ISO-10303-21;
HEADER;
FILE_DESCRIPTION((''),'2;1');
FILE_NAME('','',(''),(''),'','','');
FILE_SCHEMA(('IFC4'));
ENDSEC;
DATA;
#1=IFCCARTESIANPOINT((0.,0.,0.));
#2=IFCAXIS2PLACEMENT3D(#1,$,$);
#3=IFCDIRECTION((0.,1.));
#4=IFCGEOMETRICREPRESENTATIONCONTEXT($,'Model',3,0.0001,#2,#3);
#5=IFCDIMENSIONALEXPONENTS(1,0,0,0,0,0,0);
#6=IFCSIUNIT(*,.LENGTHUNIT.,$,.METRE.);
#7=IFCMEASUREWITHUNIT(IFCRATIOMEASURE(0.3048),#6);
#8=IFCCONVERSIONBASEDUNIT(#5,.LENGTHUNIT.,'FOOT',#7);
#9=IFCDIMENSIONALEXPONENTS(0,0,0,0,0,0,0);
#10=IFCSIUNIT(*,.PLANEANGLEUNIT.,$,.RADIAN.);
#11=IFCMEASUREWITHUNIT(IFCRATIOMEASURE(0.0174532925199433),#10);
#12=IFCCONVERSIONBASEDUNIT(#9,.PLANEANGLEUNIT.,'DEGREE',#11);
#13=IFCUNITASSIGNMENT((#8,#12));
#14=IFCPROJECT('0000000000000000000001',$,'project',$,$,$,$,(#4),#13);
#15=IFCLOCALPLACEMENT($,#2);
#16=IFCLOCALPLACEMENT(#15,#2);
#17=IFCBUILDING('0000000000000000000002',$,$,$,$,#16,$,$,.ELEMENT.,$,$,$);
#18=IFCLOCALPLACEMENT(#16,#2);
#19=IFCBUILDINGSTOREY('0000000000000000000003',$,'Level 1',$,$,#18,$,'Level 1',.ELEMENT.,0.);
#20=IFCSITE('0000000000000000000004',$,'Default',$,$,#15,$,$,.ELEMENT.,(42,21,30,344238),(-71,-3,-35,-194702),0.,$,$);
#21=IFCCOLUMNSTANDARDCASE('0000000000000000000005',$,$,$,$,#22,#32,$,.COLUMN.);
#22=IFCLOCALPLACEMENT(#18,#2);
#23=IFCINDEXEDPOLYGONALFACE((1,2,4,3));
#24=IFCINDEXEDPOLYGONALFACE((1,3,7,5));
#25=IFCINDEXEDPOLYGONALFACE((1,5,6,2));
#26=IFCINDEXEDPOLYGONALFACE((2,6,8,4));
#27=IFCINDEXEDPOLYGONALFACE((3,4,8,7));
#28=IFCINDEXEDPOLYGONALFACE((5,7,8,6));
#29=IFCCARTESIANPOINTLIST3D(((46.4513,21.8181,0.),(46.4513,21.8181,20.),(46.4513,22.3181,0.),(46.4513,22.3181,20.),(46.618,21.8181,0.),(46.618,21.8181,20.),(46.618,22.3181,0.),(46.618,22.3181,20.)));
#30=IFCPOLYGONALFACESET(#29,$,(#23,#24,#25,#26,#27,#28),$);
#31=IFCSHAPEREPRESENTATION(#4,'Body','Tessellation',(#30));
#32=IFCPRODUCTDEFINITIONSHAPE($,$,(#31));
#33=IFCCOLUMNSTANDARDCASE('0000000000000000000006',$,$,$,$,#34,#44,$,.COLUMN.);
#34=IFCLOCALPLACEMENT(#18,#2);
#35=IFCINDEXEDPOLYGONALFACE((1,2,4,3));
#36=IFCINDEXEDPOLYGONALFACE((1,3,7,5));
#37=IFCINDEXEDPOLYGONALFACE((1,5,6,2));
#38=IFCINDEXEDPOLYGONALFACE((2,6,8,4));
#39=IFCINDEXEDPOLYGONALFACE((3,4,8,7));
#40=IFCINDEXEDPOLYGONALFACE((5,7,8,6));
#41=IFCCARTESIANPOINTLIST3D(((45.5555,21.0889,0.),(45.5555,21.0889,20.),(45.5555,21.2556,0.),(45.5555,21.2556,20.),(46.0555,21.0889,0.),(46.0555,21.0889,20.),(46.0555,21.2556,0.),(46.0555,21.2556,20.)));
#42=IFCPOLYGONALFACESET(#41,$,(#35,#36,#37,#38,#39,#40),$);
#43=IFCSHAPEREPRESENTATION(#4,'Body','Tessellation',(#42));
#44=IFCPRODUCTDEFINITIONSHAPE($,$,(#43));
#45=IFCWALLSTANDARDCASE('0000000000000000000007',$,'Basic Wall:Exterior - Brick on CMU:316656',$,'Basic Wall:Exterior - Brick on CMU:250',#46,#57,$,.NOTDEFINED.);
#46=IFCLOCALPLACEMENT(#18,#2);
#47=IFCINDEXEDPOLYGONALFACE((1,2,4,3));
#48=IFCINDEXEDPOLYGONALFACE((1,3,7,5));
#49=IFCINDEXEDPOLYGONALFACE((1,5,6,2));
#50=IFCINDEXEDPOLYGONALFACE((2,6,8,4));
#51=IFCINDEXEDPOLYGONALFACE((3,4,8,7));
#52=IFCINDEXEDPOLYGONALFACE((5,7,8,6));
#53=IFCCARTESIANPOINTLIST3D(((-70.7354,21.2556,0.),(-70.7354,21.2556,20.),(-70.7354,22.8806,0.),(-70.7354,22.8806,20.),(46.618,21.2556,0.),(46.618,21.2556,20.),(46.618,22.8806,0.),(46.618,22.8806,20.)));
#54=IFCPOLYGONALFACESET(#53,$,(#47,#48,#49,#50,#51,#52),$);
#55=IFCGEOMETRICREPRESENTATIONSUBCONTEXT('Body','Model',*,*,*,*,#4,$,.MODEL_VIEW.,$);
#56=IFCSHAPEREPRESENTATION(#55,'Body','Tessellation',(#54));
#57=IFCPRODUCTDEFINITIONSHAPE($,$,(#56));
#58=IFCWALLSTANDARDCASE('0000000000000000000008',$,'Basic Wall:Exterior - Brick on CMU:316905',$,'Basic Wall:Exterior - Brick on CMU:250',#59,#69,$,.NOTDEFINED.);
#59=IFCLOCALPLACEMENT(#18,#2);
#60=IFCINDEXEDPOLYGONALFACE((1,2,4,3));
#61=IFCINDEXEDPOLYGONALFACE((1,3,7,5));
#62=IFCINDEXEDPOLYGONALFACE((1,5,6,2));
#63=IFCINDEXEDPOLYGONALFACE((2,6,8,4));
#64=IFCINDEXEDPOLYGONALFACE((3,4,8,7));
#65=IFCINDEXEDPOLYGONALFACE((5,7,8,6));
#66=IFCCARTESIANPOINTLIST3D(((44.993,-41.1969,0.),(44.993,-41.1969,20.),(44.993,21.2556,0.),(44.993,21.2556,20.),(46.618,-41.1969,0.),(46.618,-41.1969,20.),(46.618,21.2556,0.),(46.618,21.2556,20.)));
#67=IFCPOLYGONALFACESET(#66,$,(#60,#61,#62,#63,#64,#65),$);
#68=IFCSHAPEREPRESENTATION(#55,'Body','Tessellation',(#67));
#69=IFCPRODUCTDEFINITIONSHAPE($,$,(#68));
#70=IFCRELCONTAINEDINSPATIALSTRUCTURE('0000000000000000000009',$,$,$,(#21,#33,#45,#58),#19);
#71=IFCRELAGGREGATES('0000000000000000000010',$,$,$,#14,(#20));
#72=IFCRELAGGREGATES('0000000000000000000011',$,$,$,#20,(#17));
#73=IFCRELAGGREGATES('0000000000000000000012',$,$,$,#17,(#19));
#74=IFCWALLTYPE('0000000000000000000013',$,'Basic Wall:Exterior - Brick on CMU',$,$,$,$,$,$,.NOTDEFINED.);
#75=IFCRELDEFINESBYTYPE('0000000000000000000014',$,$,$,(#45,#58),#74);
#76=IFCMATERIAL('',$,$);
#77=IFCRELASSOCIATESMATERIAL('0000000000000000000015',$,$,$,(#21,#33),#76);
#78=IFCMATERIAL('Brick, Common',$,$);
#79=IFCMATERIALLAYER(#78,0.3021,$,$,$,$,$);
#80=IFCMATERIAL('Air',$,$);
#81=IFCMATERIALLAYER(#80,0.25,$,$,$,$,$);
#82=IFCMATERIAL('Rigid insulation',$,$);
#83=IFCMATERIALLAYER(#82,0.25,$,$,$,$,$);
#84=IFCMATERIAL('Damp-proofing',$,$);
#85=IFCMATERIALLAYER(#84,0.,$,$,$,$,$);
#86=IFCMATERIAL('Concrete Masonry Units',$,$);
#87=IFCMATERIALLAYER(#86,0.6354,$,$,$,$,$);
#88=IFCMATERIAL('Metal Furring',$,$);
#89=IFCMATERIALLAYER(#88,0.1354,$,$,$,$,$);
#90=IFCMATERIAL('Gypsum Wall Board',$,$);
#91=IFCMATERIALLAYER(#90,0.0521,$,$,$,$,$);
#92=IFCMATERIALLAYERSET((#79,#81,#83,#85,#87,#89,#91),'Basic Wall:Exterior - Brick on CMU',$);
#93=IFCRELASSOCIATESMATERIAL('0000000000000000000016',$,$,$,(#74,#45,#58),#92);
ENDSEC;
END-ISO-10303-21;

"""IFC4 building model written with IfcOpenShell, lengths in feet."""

from ifc_helpers import new_model, entity, si_unit, converted_unit, direction, frame, frame_2d, origin, place, context, subcontext, project, spatial, rectangle, extrude, material, layer, layer_set, layer_usage, type_object, element, save


model = new_model("IFC4")

# Units and contexts
model_context = context("Model", 3, precision=0.0001, world=origin(), true_north=direction((0.0, 1.0)))
body_context = subcontext(model_context, "Body", "Model", "MODEL_VIEW")
ifc_project = project(units=[converted_unit("LENGTHUNIT", "FOOT", entity("IfcRatioMeasure", 0.3048), si_unit("LENGTHUNIT", "METRE"), dimensions=[1, 0, 0, 0, 0, 0, 0]), converted_unit("PLANEANGLEUNIT", "DEGREE", entity("IfcRatioMeasure", 0.0174532925199433), si_unit("PLANEANGLEUNIT", "RADIAN"), dimensions=[0, 0, 0, 0, 0, 0, 0])], contexts=[model_context])

# Site, building, storey
site_placement = place(None, origin())
site = spatial("IfcSite", under=ifc_project, at=site_placement, Name="Default", CompositionType="ELEMENT", RefLatitude=(42, 21, 30, 344238), RefLongitude=(-71, -3, -35, -194702), RefElevation=0.0)
building_placement = place(site_placement, origin())
building = spatial("IfcBuilding", under=site, at=building_placement, CompositionType="ELEMENT")
storey_placement = place(building_placement, origin())
storey = spatial("IfcBuildingStorey", under=building, at=storey_placement, Name="Level 1", LongName="Level 1", CompositionType="ELEMENT", Elevation=0.0)

# Columns
ifc_material_1 = material(Name="")
wall_1_placement = place(storey_placement, frame((46.618, 22.0681, 0.0), z_axis=(0.0, 0.0, 1.0), x_axis=(-1.0, 0.0, 0.0)))
for number, where, z_axis, x_axis in (
    (1, (0.0833, 0.0, 0.0), (0.0, 0.0, 1.0), (1.0, 0.0, 0.0)),
):
    element("IfcColumnStandardCase", number, at=place(wall_1_placement, frame(where, z_axis=z_axis, x_axis=x_axis)), inside=storey, material=ifc_material_1, PredefinedType="COLUMN", context=model_context, shape_type="SweptSolid", body=[
        extrude(rectangle(XDim=0.1667, YDim=0.5), origin(), (0.0, 0.0, 1.0), 20.0),
    ])
wall_2_placement = place(storey_placement, frame((45.8055, 21.2556, 0.0), z_axis=(0.0, 0.0, 1.0), x_axis=(0.0, -1.0, 0.0)))
for number, where, z_axis, x_axis in (
    (2, (0.0833, 0.0, 0.0), (0.0, 0.0, 1.0), (1.0, 0.0, 0.0)),
):
    element("IfcColumnStandardCase", number, at=place(wall_2_placement, frame(where, z_axis=z_axis, x_axis=x_axis)), inside=storey, material=ifc_material_1, PredefinedType="COLUMN", context=model_context, shape_type="SweptSolid", body=[
        extrude(rectangle(XDim=0.1667, YDim=0.5), origin(), (0.0, 0.0, 1.0), 20.0),
    ])

# Walls
ifc_material_2 = material(Name="Brick, Common")
ifc_layer_1 = layer(ifc_material_2, 0.3021)
ifc_material_3 = material(Name="Air")
ifc_layer_2 = layer(ifc_material_3, 0.25)
ifc_material_4 = material(Name="Rigid insulation")
ifc_layer_3 = layer(ifc_material_4, 0.25)
ifc_material_5 = material(Name="Damp-proofing")
ifc_layer_4 = layer(ifc_material_5, 0.0)
ifc_material_6 = material(Name="Concrete Masonry Units")
ifc_layer_5 = layer(ifc_material_6, 0.6354)
ifc_material_7 = material(Name="Metal Furring")
ifc_layer_6 = layer(ifc_material_7, 0.1354)
ifc_material_8 = material(Name="Gypsum Wall Board")
ifc_layer_7 = layer(ifc_material_8, 0.0521)
ifc_layer_set = layer_set([ifc_layer_1, ifc_layer_2, ifc_layer_3, ifc_layer_4, ifc_layer_5, ifc_layer_6, ifc_layer_7], Name="Basic Wall:Exterior - Brick on CMU")
ifc_layer_usage_1 = layer_usage(ifc_layer_set, "AXIS2", "NEGATIVE", 0.8125)
wall_type = type_object("IfcWallType", Name="Basic Wall:Exterior - Brick on CMU", PredefinedType="NOTDEFINED", material=ifc_layer_set)
element("IfcWallStandardCase", 3, at=wall_1_placement, inside=storey, type_object=wall_type, material=ifc_layer_usage_1, Name="Basic Wall:Exterior - Brick on CMU:316656", ObjectType="Basic Wall:Exterior - Brick on CMU:250", PredefinedType="NOTDEFINED", context=body_context, shape_type="SweptSolid", body=[
    extrude(rectangle(XDim=117.3534, YDim=1.625, at=frame_2d((58.6767, 0.0), x_axis=(-1.0, 0.0))), origin(), (0.0, 0.0, 1.0), 20.0),
])
ifc_layer_usage_2 = layer_usage(ifc_layer_set, "AXIS2", "NEGATIVE", 0.8125)
element("IfcWallStandardCase", 4, at=wall_2_placement, inside=storey, type_object=wall_type, material=ifc_layer_usage_2, Name="Basic Wall:Exterior - Brick on CMU:316905", ObjectType="Basic Wall:Exterior - Brick on CMU:250", PredefinedType="NOTDEFINED", context=body_context, shape_type="SweptSolid", body=[
    extrude(rectangle(XDim=62.4525, YDim=1.625, at=frame_2d((31.2263, 0.0), x_axis=(-1.0, 0.0))), origin(), (0.0, 0.0, 1.0), 20.0),
])

save(model, "model.ifc")
